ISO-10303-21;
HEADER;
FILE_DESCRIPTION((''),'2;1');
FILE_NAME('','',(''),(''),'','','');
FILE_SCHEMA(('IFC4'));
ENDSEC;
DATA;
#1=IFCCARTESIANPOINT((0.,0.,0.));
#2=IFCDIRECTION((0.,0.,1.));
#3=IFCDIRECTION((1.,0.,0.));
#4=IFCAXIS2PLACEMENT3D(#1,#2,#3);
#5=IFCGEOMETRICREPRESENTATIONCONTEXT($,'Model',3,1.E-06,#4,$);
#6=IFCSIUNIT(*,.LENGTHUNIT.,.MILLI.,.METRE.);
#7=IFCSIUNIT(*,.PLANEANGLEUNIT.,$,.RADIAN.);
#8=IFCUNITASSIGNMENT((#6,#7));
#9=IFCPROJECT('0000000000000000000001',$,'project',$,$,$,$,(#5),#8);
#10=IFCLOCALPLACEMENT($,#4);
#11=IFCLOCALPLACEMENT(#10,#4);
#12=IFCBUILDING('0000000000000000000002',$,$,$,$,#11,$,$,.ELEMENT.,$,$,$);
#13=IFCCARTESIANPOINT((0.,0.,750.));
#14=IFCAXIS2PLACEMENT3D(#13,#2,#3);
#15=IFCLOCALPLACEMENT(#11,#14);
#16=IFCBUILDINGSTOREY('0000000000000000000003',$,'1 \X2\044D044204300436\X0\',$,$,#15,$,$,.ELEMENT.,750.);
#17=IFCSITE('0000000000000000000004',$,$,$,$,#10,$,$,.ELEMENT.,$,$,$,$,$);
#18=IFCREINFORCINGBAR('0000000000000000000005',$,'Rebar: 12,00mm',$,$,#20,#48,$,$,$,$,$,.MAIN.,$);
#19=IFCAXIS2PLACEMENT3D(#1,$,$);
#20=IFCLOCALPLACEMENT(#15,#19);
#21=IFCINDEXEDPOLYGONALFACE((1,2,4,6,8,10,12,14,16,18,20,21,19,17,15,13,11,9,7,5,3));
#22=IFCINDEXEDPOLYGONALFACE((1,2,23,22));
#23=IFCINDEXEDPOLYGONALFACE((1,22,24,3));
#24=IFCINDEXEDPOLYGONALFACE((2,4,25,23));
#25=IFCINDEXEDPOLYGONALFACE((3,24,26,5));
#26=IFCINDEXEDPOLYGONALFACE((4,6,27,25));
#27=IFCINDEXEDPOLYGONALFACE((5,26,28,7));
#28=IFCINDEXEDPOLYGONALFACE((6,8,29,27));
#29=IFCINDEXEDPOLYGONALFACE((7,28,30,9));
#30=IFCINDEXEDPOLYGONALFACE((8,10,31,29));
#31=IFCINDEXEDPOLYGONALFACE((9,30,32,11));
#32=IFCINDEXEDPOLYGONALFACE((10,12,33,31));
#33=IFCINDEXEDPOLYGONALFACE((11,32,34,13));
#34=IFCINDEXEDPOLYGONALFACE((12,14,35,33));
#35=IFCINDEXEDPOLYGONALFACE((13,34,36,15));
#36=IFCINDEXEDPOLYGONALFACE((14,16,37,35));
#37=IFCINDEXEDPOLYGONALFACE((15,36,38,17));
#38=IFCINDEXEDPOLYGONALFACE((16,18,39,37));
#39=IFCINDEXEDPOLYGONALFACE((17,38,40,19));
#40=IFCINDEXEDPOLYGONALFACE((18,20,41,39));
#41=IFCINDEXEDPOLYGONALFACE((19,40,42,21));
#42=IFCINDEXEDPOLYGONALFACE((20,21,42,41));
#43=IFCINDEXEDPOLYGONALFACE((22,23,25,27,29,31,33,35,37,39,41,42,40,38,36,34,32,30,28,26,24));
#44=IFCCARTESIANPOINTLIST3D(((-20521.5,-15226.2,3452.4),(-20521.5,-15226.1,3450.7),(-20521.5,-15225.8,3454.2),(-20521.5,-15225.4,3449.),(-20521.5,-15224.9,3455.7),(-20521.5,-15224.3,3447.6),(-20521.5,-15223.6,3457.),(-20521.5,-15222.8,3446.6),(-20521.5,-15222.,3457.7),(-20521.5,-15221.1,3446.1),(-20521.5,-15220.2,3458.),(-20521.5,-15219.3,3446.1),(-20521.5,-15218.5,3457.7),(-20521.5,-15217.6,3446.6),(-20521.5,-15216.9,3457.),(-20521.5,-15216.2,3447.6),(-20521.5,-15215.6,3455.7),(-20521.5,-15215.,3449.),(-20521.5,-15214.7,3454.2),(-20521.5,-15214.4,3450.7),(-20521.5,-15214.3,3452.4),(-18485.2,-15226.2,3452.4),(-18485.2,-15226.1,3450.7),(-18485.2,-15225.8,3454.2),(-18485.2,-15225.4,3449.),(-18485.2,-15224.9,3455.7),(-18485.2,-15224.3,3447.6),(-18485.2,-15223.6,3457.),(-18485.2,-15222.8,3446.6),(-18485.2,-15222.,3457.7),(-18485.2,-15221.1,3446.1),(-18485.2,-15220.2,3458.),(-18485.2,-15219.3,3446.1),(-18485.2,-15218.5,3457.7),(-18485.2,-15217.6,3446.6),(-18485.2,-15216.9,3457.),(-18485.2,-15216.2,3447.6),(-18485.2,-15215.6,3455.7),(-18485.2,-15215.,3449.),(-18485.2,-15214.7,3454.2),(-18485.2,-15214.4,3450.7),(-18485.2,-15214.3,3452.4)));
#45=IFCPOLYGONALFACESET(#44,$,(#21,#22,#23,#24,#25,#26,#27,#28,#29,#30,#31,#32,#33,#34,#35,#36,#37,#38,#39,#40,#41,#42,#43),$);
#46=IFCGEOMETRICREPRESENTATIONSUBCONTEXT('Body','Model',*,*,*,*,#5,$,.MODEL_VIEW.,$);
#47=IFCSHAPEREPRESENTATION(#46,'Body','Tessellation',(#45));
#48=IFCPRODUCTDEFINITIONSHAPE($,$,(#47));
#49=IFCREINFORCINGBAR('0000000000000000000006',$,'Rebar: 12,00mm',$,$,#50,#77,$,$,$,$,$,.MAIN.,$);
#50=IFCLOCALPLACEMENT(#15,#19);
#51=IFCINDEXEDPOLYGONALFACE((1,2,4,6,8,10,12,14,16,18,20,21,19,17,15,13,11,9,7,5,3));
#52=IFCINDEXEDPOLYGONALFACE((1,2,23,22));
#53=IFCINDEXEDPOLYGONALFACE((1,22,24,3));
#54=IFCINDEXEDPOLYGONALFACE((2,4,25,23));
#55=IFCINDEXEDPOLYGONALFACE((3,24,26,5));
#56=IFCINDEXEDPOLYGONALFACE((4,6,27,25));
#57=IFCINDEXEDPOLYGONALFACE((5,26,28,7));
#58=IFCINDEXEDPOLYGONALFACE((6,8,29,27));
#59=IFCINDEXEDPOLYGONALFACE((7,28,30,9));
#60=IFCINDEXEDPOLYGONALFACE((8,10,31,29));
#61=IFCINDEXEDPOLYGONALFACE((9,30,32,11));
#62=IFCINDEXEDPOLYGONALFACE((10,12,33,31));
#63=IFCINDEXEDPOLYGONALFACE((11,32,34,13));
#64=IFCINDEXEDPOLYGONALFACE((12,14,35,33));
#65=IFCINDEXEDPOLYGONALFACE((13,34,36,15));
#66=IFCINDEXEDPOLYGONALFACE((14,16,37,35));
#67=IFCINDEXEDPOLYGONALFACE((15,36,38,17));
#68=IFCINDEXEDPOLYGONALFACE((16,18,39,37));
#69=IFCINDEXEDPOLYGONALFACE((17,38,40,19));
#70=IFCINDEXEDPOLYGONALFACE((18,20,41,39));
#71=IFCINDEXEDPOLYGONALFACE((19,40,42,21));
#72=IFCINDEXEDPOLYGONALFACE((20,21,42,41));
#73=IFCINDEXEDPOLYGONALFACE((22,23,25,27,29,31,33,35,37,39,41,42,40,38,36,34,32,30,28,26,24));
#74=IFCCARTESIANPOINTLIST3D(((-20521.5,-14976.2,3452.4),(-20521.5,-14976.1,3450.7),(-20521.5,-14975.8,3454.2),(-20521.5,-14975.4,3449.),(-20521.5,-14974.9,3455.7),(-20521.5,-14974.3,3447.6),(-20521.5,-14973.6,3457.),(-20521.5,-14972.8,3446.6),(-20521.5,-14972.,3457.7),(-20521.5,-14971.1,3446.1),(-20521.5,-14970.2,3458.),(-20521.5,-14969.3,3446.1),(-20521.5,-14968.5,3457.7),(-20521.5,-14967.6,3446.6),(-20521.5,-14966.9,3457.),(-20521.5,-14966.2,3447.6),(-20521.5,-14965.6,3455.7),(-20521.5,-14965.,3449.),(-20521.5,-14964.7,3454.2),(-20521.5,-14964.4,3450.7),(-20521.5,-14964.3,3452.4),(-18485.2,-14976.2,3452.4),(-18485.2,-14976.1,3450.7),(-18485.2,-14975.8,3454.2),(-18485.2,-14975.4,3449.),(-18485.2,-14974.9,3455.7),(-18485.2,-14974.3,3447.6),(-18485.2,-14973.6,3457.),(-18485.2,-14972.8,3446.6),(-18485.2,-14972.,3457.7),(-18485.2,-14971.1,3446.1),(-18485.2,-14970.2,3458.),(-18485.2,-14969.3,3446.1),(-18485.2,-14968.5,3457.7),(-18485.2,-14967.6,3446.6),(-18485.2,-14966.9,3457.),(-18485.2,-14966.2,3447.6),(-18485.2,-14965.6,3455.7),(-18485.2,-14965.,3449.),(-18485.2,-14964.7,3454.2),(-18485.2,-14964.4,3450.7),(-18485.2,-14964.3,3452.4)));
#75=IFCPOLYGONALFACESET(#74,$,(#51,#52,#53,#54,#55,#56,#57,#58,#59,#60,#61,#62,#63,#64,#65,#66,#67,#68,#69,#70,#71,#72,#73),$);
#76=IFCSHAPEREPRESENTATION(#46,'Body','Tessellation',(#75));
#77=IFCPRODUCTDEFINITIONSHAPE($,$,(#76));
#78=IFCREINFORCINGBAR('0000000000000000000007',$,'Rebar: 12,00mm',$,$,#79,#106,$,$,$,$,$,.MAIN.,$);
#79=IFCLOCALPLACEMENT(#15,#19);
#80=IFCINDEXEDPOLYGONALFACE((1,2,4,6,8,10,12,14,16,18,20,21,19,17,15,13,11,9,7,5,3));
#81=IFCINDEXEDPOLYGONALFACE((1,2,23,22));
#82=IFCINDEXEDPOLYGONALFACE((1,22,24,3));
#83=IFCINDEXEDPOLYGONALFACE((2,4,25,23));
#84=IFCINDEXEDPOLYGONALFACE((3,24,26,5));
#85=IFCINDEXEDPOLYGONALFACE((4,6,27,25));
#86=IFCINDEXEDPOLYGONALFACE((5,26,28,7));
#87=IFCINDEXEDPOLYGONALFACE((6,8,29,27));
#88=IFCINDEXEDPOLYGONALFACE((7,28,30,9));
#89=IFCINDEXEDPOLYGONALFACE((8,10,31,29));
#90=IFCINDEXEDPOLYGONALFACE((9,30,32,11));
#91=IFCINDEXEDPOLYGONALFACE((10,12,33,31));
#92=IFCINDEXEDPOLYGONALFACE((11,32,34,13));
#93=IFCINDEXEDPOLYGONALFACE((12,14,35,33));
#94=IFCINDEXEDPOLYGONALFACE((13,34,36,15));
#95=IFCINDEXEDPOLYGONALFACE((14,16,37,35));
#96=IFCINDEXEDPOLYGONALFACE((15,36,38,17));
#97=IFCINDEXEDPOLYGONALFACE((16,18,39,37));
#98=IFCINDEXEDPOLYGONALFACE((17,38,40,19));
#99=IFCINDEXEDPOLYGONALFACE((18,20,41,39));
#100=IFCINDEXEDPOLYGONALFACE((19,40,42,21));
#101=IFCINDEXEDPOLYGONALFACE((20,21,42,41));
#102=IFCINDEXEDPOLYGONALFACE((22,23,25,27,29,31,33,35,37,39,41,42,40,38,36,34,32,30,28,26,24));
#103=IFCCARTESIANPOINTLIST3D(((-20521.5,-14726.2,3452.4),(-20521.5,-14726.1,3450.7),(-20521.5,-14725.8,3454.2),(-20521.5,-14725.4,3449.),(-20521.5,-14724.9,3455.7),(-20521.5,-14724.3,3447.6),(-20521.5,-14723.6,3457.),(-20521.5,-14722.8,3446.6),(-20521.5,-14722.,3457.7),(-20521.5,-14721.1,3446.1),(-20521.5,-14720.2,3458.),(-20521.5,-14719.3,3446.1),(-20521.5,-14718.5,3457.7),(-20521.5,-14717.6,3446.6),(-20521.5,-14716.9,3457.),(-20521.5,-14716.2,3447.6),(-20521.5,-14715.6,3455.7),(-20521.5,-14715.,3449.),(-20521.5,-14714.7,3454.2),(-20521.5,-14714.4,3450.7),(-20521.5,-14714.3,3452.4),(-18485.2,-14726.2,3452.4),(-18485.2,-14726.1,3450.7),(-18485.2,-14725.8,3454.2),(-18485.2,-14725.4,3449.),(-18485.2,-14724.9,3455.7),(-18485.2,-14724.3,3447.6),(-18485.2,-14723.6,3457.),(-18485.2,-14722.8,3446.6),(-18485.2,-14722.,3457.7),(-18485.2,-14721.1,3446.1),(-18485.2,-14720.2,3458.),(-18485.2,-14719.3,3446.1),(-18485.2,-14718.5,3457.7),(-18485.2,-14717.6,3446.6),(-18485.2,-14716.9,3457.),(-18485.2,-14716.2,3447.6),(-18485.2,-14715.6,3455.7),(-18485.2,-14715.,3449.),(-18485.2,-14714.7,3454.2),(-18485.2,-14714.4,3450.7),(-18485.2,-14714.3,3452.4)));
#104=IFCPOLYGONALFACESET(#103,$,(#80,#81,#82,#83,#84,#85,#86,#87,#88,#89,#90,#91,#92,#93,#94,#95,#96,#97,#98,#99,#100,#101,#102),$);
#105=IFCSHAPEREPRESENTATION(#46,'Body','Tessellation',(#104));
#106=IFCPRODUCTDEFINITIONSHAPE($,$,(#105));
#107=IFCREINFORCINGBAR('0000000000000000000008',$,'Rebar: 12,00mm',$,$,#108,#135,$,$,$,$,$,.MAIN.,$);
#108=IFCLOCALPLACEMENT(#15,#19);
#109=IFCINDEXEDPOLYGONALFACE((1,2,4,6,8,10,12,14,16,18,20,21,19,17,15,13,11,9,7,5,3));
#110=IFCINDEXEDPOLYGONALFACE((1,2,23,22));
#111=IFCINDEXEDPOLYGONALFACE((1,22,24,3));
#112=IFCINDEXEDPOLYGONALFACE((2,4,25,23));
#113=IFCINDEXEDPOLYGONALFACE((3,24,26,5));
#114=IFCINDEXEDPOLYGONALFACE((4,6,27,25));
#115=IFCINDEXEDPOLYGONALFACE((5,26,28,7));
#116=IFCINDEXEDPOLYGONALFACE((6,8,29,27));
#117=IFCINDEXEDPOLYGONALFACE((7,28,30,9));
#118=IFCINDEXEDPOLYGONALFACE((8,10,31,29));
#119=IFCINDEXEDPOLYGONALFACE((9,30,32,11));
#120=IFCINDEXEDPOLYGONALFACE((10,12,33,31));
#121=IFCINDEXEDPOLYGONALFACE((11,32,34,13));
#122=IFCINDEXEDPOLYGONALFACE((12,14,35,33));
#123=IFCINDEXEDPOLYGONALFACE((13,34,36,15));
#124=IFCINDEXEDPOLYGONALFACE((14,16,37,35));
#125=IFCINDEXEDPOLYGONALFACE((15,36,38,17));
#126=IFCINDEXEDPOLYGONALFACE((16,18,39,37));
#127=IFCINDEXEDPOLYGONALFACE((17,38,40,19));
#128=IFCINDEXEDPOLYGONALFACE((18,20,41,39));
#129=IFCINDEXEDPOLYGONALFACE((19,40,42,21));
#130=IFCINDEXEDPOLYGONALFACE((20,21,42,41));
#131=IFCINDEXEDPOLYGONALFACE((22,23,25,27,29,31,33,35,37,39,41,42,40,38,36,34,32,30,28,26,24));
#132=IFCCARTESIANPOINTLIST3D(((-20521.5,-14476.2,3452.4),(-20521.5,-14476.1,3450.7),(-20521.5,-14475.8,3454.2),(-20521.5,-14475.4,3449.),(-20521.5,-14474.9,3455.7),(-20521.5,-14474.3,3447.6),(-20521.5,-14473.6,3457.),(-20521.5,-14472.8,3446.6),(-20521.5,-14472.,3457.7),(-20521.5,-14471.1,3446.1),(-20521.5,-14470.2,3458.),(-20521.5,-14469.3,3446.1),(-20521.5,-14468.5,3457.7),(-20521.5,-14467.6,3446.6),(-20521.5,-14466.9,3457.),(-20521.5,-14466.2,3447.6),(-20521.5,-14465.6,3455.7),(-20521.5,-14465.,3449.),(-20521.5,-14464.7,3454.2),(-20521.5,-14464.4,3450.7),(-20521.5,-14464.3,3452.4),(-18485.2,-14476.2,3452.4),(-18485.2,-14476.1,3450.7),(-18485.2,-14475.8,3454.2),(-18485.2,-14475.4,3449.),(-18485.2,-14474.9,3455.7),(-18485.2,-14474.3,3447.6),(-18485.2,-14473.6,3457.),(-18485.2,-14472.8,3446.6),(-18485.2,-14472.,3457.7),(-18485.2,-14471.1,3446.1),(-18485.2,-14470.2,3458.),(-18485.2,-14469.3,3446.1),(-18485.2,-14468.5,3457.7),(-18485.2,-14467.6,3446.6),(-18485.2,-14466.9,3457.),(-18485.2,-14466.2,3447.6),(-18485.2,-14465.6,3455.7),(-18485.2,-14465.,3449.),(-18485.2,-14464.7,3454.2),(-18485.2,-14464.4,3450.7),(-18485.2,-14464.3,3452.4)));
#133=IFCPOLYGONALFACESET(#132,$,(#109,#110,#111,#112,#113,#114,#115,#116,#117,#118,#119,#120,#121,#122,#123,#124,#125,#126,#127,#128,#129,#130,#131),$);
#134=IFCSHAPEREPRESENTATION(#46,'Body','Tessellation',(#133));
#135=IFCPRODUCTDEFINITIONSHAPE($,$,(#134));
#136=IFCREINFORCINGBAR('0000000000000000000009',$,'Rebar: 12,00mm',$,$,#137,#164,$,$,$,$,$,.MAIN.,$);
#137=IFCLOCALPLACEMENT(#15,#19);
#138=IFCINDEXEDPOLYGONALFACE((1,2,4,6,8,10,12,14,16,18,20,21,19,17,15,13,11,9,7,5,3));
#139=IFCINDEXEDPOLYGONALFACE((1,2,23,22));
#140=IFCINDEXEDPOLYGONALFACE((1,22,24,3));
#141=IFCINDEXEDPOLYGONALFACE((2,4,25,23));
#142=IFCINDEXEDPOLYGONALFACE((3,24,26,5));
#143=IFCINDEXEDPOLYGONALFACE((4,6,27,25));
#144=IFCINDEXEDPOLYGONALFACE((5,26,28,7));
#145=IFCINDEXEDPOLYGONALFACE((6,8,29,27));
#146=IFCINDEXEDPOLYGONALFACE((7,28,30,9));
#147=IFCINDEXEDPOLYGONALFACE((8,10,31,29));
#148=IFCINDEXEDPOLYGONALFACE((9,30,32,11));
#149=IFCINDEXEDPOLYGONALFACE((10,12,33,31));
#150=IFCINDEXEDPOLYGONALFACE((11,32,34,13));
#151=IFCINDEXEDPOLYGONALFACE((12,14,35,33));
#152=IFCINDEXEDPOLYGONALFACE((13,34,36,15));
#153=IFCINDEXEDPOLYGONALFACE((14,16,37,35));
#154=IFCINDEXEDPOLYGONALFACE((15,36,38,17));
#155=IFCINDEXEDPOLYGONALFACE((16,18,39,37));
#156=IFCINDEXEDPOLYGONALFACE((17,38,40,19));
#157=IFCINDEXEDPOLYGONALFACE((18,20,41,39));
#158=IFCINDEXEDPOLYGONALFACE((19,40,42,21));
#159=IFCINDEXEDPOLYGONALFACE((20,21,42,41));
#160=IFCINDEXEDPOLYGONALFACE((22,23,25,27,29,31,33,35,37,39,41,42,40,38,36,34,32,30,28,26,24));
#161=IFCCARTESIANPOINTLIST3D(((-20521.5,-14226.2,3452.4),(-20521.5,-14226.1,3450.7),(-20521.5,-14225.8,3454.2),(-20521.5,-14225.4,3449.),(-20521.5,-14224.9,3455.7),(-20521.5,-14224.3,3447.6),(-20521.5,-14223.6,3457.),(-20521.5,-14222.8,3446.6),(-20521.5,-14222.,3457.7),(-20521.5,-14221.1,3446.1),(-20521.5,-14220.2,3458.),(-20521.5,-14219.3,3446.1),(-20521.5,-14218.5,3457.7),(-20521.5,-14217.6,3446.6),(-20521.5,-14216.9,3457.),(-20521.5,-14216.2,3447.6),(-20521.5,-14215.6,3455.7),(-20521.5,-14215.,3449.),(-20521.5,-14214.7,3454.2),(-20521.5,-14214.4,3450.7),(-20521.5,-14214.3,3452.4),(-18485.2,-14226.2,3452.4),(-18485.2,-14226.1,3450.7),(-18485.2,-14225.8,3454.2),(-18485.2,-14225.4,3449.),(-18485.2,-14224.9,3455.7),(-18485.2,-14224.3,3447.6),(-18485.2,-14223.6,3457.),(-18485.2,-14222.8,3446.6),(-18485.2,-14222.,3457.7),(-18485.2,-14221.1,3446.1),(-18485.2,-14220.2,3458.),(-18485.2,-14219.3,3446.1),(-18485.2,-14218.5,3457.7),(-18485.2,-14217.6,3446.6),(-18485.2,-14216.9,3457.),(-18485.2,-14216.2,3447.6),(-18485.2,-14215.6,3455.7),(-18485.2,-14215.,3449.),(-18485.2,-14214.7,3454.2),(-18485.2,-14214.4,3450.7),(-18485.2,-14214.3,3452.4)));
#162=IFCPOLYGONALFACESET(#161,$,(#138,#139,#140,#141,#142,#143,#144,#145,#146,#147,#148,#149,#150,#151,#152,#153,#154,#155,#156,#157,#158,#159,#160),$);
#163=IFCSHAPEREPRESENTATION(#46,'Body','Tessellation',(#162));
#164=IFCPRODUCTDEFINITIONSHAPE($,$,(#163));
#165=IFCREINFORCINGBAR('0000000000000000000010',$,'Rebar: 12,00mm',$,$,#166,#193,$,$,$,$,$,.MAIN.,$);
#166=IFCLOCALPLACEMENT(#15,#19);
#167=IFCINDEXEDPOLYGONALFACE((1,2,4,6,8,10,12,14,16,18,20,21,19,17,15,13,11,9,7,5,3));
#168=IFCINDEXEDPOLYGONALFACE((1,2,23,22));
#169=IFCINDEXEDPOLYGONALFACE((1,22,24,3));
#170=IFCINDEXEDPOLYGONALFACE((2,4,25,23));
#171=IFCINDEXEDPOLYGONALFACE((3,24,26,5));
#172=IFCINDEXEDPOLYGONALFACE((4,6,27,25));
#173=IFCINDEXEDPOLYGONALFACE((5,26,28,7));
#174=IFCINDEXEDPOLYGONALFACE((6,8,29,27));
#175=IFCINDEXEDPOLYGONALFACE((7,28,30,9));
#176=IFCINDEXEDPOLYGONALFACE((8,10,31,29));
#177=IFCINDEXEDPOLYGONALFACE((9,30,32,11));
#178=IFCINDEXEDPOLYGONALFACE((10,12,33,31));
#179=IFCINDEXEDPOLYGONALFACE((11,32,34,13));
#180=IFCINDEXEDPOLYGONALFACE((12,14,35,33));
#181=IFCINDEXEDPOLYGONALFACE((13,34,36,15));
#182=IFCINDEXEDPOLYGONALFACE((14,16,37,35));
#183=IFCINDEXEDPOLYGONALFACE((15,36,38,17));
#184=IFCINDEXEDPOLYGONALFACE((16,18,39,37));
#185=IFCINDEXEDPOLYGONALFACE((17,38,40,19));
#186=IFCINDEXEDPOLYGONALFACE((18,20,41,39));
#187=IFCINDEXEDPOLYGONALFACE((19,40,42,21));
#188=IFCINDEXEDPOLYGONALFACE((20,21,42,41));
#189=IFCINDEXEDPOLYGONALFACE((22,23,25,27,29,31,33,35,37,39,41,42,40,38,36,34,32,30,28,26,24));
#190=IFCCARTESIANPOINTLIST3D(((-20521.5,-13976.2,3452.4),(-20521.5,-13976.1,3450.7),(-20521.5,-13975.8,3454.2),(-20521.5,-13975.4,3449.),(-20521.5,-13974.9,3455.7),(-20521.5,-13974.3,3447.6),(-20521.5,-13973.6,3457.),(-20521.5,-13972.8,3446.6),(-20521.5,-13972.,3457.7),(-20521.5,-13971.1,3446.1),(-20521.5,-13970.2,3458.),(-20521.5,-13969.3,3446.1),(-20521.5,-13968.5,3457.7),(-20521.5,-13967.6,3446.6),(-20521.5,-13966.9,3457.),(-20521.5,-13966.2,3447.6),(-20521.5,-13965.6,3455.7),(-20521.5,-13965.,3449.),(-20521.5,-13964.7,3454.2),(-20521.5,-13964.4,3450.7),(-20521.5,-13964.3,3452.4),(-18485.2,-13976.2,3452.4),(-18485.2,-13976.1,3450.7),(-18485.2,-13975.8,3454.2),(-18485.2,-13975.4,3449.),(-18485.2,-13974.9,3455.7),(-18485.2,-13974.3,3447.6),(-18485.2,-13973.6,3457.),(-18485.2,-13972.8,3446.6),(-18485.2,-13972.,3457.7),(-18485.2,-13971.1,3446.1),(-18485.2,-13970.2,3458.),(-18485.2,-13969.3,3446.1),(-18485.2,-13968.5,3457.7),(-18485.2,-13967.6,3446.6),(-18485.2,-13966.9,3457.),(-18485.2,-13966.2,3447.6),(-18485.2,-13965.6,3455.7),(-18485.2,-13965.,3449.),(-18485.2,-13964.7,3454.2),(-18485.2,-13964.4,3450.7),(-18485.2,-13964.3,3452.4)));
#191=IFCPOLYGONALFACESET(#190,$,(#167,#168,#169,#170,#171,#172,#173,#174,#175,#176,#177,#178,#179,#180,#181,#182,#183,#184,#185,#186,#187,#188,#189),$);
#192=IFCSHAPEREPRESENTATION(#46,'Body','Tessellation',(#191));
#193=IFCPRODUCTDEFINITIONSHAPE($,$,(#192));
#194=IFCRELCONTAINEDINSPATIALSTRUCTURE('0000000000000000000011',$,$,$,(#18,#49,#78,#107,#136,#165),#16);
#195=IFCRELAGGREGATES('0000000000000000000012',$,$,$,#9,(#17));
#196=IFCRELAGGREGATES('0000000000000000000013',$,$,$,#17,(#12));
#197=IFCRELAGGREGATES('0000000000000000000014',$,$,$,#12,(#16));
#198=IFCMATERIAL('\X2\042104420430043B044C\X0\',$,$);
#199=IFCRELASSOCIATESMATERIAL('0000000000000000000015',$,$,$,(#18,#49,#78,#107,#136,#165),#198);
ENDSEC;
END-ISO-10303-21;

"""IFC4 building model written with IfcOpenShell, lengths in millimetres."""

from ifc_helpers import new_model, entity, si_unit, frame, origin_with_axes, place, context, subcontext, project, spatial, source, transform, mapped, material, element, save


model = new_model("IFC4")

# Units and contexts
model_context = context("Model", 3, precision=1e-06, world=origin_with_axes())
body_context = subcontext(model_context, "Body", "Model", "MODEL_VIEW")
ifc_project = project(units=[si_unit("LENGTHUNIT", "METRE", prefix="MILLI"), si_unit("PLANEANGLEUNIT", "RADIAN")], contexts=[model_context])

# Site, building, storey
site_placement = place(None, origin_with_axes())
site = spatial("IfcSite", under=ifc_project, at=site_placement, CompositionType="ELEMENT")
building_placement = place(site_placement, origin_with_axes())
building = spatial("IfcBuilding", under=site, at=building_placement, CompositionType="ELEMENT")
storey_placement = place(building_placement, frame((0.0, 0.0, 750.0), z_axis=(0.0, 0.0, 1.0), x_axis=(1.0, 0.0, 0.0)))
storey = spatial("IfcBuildingStorey", under=building, at=storey_placement, Name="1 этаж", CompositionType="ELEMENT", Elevation=750.0)

# Reinforcing bars
ifc_material = material(Name="Сталь")
shared_shape_1 = source(origin_with_axes(), body_context, "Body", "AdvancedSweptSolid", [
    entity("IfcSweptDiskSolid", entity("IfcIndexedPolyCurve", entity("IfcCartesianPointList3D", [[0.0, 0.0, 0.0], [2036.2, 0.0, 0.0]]), [entity("IfcLineIndex", [1, 2])]), 6.0),
])
reinforcing_bar_1_placement = place(storey_placement, origin_with_axes())
element("IfcReinforcingBar", 1, at=reinforcing_bar_1_placement, inside=storey, material=ifc_material, Name="Rebar: 12,00mm", PredefinedType="MAIN", context=body_context, shape_type="MappedRepresentation", body=[
    mapped(shared_shape_1, transform((-20521.5, -15220.2, 3452.0), x_axis=(1.0, 0.0, 0.0), y_axis=(0.0, 1.0, 0.0), z_axis=(0.0, 0.0, 1.0), scale=1.0)),
])
reinforcing_bar_2_placement = place(storey_placement, origin_with_axes())
element("IfcReinforcingBar", 2, at=reinforcing_bar_2_placement, inside=storey, material=ifc_material, Name="Rebar: 12,00mm", PredefinedType="MAIN", context=body_context, shape_type="MappedRepresentation", body=[
    mapped(shared_shape_1, transform((-20521.5, -14970.2, 3452.0), x_axis=(1.0, 0.0, 0.0), y_axis=(0.0, 1.0, 0.0), z_axis=(0.0, 0.0, 1.0), scale=1.0)),
])
reinforcing_bar_3_placement = place(storey_placement, origin_with_axes())
element("IfcReinforcingBar", 3, at=reinforcing_bar_3_placement, inside=storey, material=ifc_material, Name="Rebar: 12,00mm", PredefinedType="MAIN", context=body_context, shape_type="MappedRepresentation", body=[
    mapped(shared_shape_1, transform((-20521.5, -14720.2, 3452.0), x_axis=(1.0, 0.0, 0.0), y_axis=(0.0, 1.0, 0.0), z_axis=(0.0, 0.0, 1.0), scale=1.0)),
])
reinforcing_bar_4_placement = place(storey_placement, origin_with_axes())
element("IfcReinforcingBar", 4, at=reinforcing_bar_4_placement, inside=storey, material=ifc_material, Name="Rebar: 12,00mm", PredefinedType="MAIN", context=body_context, shape_type="MappedRepresentation", body=[
    mapped(shared_shape_1, transform((-20521.5, -14470.2, 3452.0), x_axis=(1.0, 0.0, 0.0), y_axis=(0.0, 1.0, 0.0), z_axis=(0.0, 0.0, 1.0), scale=1.0)),
])
reinforcing_bar_5_placement = place(storey_placement, origin_with_axes())
element("IfcReinforcingBar", 5, at=reinforcing_bar_5_placement, inside=storey, material=ifc_material, Name="Rebar: 12,00mm", PredefinedType="MAIN", context=body_context, shape_type="MappedRepresentation", body=[
    mapped(shared_shape_1, transform((-20521.5, -14220.2, 3452.0), x_axis=(1.0, 0.0, 0.0), y_axis=(0.0, 1.0, 0.0), z_axis=(0.0, 0.0, 1.0), scale=1.0)),
])
reinforcing_bar_6_placement = place(storey_placement, origin_with_axes())
element("IfcReinforcingBar", 6, at=reinforcing_bar_6_placement, inside=storey, material=ifc_material, Name="Rebar: 12,00mm", PredefinedType="MAIN", context=body_context, shape_type="MappedRepresentation", body=[
    mapped(shared_shape_1, transform((-20521.5, -13970.2, 3452.0), x_axis=(1.0, 0.0, 0.0), y_axis=(0.0, 1.0, 0.0), z_axis=(0.0, 0.0, 1.0), scale=1.0)),
])

save(model, "model.ifc")
